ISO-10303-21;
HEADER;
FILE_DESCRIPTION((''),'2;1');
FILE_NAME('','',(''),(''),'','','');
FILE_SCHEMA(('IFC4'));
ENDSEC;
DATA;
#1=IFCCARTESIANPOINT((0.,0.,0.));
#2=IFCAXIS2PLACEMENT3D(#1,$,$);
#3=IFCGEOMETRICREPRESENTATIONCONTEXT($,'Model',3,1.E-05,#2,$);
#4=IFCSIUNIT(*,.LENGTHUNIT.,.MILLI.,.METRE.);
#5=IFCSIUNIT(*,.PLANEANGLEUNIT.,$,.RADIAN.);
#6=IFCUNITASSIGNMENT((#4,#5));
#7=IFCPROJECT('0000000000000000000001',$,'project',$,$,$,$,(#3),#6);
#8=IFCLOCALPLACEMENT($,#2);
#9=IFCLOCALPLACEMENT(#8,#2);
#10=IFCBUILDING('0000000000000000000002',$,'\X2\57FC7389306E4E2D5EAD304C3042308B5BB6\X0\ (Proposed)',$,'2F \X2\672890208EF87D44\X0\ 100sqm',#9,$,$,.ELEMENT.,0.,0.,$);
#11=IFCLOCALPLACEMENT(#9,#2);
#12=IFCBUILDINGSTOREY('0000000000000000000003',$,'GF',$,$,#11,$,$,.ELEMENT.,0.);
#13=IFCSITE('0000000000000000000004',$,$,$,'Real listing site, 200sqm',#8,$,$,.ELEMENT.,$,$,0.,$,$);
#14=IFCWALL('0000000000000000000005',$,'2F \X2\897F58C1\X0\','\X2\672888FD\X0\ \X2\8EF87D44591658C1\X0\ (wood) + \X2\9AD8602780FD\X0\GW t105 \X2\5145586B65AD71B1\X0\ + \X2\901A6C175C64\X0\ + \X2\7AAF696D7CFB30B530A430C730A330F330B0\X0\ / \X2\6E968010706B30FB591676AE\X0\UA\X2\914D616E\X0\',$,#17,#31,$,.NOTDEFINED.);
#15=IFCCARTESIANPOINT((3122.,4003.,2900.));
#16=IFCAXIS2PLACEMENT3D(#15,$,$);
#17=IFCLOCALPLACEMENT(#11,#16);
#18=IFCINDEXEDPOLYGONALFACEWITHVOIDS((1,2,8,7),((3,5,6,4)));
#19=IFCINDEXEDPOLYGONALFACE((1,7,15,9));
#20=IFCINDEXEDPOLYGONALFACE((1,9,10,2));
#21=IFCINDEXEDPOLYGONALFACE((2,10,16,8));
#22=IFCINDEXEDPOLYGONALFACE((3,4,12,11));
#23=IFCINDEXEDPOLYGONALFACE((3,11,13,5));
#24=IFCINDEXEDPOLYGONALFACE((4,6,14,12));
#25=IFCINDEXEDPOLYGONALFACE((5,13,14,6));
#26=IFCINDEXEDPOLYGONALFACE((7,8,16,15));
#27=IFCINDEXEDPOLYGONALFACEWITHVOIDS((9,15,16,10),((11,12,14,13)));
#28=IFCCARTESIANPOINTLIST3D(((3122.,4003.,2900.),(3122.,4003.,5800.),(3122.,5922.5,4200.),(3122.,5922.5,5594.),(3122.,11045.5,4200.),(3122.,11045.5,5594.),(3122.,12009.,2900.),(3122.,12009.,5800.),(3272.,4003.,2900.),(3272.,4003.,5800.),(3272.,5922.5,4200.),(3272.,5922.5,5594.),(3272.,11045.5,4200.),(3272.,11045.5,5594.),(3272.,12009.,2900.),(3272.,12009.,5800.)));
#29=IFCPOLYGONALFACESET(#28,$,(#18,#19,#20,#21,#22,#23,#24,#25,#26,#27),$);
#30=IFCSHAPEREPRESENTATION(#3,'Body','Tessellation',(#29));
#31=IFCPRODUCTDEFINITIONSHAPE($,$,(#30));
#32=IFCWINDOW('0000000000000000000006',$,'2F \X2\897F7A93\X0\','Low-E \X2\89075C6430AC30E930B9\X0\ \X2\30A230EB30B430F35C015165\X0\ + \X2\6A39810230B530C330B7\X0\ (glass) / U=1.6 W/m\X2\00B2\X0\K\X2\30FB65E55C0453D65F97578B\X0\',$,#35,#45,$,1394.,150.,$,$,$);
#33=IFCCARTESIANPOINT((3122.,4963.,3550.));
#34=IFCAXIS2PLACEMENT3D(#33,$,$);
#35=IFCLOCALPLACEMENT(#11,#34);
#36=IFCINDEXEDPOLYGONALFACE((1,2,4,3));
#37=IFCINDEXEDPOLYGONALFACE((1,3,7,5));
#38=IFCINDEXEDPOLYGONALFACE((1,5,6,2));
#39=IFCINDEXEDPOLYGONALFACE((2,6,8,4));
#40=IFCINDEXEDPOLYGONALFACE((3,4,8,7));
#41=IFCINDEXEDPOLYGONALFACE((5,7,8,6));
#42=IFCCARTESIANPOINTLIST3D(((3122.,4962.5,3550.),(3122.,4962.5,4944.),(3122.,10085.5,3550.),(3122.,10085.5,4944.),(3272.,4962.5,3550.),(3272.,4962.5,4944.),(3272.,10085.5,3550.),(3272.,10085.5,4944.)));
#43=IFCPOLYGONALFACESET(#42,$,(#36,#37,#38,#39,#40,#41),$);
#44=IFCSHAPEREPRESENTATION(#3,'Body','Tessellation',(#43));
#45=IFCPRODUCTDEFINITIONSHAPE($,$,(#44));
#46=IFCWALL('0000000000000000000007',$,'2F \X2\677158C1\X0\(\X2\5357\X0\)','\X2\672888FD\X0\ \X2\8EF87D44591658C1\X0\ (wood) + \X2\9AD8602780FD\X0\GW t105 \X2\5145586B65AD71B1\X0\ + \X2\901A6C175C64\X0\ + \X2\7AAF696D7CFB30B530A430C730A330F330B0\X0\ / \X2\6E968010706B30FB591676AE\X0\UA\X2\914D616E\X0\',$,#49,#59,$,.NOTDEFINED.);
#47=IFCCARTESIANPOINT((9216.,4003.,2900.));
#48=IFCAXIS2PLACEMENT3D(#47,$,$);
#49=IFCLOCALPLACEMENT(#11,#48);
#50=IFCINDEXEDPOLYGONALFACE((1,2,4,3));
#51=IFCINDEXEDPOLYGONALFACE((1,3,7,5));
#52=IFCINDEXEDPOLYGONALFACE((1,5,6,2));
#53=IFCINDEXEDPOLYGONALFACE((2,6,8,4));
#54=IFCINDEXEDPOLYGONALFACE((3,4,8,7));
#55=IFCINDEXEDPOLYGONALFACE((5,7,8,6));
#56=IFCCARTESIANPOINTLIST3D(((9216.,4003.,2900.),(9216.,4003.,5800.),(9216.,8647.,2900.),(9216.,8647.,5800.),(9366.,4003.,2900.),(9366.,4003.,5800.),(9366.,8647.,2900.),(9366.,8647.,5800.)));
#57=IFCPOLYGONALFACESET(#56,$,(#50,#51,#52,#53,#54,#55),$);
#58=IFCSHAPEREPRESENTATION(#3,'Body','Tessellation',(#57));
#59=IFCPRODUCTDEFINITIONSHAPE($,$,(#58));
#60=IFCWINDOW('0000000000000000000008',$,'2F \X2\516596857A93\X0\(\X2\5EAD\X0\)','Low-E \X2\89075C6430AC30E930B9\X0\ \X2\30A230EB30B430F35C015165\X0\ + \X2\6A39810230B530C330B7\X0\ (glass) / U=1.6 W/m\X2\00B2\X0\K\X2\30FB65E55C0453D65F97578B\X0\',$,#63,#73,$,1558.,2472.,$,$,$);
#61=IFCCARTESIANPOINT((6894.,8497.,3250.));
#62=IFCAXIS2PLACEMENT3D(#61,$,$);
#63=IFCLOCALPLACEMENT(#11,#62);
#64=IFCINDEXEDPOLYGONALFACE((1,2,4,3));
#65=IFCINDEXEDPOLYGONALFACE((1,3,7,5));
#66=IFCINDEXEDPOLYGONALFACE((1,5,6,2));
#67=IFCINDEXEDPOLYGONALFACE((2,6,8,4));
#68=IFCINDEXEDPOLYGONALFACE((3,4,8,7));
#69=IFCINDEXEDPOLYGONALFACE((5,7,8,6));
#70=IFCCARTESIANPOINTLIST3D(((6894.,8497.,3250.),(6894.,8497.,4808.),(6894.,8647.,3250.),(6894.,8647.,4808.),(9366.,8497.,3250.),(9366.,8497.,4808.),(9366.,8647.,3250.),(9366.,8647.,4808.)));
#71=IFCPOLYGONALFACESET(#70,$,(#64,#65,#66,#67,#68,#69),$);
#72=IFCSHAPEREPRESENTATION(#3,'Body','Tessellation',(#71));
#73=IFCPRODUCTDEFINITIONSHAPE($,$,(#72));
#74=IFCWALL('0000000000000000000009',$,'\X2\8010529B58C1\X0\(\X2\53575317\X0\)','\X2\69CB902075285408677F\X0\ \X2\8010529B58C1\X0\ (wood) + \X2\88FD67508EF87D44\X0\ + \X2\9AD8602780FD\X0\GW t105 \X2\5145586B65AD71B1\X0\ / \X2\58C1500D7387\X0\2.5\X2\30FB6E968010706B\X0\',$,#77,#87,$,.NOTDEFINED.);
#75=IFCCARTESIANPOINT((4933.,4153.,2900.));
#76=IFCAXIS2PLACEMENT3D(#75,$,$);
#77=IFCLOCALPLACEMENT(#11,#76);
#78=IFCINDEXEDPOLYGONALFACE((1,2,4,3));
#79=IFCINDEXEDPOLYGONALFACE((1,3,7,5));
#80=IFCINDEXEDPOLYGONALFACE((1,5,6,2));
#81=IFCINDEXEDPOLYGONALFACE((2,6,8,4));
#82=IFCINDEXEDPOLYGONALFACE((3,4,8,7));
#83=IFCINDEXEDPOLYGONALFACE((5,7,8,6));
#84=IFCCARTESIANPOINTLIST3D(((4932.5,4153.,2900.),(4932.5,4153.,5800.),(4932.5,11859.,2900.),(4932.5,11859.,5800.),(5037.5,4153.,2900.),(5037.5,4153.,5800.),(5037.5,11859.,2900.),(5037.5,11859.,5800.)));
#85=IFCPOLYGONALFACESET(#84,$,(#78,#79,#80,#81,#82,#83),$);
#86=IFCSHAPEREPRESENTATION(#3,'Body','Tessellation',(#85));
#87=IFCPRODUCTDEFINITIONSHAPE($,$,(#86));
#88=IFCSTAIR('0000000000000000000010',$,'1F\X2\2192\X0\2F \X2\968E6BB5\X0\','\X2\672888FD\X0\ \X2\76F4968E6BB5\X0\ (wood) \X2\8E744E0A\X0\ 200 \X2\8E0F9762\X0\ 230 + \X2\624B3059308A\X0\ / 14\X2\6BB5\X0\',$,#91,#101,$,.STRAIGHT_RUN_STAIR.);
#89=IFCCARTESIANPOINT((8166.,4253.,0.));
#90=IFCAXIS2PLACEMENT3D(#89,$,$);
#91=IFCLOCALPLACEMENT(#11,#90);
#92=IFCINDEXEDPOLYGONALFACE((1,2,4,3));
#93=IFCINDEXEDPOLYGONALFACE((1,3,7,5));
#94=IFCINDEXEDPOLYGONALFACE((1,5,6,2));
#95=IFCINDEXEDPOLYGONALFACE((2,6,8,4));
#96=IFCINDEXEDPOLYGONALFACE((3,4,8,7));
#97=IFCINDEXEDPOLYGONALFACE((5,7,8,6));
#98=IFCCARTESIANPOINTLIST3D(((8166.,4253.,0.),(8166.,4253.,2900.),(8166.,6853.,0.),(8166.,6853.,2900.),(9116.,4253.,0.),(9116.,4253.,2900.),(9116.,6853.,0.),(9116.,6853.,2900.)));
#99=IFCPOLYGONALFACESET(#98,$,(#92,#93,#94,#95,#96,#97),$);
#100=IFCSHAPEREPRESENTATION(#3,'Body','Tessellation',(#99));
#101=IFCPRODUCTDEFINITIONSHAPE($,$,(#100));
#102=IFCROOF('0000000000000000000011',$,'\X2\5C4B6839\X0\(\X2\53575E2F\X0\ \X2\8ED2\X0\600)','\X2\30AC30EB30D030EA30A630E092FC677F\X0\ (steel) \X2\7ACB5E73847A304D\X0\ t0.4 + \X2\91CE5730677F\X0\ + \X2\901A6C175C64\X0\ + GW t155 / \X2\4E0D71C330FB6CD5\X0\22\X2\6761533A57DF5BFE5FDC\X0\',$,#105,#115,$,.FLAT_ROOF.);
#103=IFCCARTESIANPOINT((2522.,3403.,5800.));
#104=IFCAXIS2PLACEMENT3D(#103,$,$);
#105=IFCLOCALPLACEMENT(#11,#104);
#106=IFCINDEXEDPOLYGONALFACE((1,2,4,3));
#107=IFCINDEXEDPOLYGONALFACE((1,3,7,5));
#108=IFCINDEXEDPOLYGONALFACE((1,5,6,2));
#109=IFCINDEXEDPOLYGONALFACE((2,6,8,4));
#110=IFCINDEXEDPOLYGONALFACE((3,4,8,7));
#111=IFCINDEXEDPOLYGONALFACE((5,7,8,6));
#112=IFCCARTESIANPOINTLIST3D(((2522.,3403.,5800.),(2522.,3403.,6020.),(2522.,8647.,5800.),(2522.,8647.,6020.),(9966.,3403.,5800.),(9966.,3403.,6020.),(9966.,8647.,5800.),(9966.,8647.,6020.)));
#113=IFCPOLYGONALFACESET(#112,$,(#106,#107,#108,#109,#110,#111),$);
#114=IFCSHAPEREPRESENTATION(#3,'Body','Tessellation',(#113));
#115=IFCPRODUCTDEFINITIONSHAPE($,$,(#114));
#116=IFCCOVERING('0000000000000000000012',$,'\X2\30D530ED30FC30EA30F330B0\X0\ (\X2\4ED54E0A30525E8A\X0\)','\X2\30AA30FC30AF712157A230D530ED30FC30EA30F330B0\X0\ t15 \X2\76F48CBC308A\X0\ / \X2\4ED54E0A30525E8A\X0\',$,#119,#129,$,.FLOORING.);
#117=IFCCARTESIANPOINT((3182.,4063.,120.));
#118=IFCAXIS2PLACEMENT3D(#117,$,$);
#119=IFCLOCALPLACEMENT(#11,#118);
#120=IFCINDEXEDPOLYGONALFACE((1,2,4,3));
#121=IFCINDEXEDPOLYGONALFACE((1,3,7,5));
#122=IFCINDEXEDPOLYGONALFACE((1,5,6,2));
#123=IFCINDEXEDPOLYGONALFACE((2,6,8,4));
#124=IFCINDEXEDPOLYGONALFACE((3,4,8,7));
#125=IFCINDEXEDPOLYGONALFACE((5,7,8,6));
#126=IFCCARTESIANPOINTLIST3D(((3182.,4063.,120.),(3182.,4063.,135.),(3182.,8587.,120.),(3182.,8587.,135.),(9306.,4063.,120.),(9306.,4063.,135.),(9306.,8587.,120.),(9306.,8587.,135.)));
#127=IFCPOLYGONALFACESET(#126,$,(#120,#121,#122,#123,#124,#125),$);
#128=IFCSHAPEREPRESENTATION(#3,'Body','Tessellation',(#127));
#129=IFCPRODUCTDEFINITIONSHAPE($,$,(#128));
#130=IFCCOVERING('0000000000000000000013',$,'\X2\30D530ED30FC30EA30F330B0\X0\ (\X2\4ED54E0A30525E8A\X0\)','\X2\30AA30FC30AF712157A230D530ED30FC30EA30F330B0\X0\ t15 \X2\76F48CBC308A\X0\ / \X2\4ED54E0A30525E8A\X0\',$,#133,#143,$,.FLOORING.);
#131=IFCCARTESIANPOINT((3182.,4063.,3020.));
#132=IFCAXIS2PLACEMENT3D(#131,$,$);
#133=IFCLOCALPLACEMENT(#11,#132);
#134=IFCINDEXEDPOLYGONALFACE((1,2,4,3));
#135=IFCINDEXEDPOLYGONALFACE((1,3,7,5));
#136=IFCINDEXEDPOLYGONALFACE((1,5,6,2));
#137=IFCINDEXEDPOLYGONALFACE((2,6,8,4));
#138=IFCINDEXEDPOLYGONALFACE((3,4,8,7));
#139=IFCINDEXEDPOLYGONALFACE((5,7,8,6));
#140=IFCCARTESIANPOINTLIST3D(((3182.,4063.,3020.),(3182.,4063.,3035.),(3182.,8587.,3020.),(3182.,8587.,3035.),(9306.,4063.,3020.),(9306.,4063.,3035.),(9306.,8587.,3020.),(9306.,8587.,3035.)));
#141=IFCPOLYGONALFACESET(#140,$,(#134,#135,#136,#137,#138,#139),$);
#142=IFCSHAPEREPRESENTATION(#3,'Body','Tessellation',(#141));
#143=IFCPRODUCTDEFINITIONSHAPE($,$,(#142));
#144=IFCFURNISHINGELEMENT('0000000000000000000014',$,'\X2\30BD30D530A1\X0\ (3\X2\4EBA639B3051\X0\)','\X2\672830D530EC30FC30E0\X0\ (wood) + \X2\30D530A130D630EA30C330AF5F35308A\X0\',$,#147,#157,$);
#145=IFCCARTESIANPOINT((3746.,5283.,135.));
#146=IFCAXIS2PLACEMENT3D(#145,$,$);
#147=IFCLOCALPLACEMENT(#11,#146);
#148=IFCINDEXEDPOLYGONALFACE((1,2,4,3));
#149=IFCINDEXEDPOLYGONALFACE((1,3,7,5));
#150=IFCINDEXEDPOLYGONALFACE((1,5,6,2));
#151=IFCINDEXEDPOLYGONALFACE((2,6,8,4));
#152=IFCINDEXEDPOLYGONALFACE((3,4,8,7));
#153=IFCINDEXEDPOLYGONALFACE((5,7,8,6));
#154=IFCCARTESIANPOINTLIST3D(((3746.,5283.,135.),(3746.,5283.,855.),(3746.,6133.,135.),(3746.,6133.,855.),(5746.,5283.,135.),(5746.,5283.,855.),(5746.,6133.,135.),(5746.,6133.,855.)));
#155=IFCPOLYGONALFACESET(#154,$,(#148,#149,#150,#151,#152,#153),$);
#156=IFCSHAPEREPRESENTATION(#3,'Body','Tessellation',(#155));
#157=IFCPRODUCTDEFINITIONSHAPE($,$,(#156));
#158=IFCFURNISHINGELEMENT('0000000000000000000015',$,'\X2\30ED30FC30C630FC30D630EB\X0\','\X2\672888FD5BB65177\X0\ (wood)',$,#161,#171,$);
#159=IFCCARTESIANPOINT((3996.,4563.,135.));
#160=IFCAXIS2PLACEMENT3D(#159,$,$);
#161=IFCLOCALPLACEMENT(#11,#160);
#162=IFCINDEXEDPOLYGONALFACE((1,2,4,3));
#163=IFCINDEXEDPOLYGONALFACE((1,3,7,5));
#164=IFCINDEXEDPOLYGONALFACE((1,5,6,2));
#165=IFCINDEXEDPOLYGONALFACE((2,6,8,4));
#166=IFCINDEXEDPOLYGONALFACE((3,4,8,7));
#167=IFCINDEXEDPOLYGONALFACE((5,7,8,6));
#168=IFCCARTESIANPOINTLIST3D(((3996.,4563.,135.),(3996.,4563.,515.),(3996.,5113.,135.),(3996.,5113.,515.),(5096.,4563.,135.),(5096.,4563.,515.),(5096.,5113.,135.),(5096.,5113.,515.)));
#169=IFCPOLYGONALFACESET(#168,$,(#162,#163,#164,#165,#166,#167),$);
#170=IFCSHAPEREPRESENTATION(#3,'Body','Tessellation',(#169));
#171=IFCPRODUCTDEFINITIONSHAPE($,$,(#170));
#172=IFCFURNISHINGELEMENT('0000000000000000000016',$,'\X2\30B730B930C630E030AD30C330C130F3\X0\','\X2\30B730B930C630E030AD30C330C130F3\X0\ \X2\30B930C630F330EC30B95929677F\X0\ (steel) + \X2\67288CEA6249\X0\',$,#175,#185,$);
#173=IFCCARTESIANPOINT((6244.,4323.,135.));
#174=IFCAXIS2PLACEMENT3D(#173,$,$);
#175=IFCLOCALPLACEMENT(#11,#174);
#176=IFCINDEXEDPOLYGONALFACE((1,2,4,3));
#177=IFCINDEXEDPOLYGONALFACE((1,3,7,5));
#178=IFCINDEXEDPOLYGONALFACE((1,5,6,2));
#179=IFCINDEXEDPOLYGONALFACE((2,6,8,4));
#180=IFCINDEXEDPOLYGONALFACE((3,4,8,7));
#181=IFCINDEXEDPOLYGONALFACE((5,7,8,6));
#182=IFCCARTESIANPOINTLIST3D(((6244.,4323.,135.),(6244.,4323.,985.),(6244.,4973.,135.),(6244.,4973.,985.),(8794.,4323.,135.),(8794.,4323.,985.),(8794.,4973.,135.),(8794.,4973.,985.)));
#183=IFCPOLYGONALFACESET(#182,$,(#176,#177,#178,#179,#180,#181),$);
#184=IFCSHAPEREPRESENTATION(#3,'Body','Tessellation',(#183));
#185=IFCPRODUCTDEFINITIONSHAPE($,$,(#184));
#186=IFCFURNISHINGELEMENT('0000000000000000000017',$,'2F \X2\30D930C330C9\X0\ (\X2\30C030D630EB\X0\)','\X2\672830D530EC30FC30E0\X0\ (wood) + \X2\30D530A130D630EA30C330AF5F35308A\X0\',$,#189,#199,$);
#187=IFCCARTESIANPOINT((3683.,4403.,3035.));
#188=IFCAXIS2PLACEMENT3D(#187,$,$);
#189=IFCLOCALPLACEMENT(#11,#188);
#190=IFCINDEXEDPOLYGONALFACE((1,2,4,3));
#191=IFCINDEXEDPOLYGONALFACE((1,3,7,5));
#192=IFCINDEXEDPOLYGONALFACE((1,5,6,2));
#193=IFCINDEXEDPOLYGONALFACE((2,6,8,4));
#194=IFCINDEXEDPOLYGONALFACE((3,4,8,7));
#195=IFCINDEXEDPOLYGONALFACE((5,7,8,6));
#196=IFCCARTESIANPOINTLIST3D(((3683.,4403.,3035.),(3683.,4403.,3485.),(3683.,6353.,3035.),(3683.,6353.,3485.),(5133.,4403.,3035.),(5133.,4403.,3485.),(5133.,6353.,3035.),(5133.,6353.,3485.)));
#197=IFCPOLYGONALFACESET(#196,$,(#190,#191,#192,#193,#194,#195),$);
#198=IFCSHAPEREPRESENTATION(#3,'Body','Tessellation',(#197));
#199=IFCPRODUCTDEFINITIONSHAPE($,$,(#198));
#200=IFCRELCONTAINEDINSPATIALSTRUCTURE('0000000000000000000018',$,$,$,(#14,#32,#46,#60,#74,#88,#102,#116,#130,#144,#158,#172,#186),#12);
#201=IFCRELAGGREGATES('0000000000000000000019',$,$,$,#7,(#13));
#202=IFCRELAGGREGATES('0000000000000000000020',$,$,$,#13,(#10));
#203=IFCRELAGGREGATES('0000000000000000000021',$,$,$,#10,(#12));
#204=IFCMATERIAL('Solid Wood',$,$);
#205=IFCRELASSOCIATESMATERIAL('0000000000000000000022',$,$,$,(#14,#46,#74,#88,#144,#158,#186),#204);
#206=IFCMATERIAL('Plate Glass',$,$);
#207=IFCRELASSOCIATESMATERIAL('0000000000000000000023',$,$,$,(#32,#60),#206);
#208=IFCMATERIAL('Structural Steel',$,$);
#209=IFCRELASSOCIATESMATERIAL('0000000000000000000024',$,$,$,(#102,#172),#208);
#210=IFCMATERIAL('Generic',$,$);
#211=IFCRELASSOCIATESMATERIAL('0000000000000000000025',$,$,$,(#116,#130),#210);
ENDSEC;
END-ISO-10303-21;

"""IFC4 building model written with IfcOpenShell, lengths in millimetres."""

from ifc_helpers import new_model, si_unit, frame, frame_2d, origin, place, context, project, spatial, rectangle, extrude, material, element, fill, save


model = new_model("IFC4")

# Units and contexts
model_context = context("Model", 3, precision=1e-05, world=origin())
ifc_project = project(units=[si_unit("LENGTHUNIT", "METRE", prefix="MILLI"), si_unit("PLANEANGLEUNIT", "RADIAN")], contexts=[model_context])

# Site, building, storey
site_placement = place(None, origin())
site = spatial("IfcSite", under=ifc_project, at=site_placement, ObjectType="Real listing site, 200sqm", CompositionType="ELEMENT", RefElevation=0.0)
building_placement = place(site_placement, origin())
building = spatial("IfcBuilding", under=site, at=building_placement, Name="埼玉の中庭がある家 (Proposed)", ObjectType="2F 木造軸組 100sqm", CompositionType="ELEMENT", ElevationOfRefHeight=0.0, ElevationOfTerrain=0.0)
storey_placement = place(building_placement, origin())
storey = spatial("IfcBuildingStorey", under=building, at=storey_placement, Name="GF", CompositionType="ELEMENT", Elevation=0.0)

# Shared definitions
ifc_material_1 = material(Name="Solid Wood")

# Shared definitions
ifc_material_2 = material(Name="Plate Glass")

# Walls, openings, windows
wall_1_placement = place(storey_placement, frame((3122.0, 4003.0, 2900.0)))
wall_1 = element("IfcWall", 1, at=wall_1_placement, inside=storey, material=ifc_material_1, Name="2F 西壁", Description="木製 軸組外壁 (wood) + 高性能GW t105 充填断熱 + 通気層 + 窯業系サイディング / 準耐火・外皮UA配慮", PredefinedType="NOTDEFINED", context=model_context, shape_type="SweptSolid", body=[
    extrude(rectangle(XDim=150.0, YDim=8006.0, at=frame_2d((75.0, 4003.0))), frame((3122.0, 4003.0, 2900.0)), (0.0, 0.0, 1.0), 2900.0),
])
opening_1_placement = place(storey_placement, frame((3122.0, 4963.0, 3550.0)))
opening_1 = element("IfcOpeningElement", 2, at=opening_1_placement, cuts=wall_1, PredefinedType="NOTDEFINED", context=model_context, shape_type="SweptSolid", body=[
    extrude(rectangle(XDim=150.0, YDim=5123.0, at=frame_2d((75.0, 2561.0))), frame((3122.0, 4963.0, 3550.0)), (0.0, 0.0, 1.0), 1394.0),
])
window_1_placement = place(storey_placement, frame((3122.0, 4963.0, 3550.0)))
window_1 = element("IfcWindow", 3, at=window_1_placement, inside=storey, material=ifc_material_2, Name="2F 西窓", Description="Low-E 複層ガラス アルゴン封入 + 樹脂サッシ (glass) / U=1.6 W/m²K・日射取得型", OverallHeight=1394.0, OverallWidth=150.0, context=model_context, shape_type="SweptSolid", body=[
    extrude(rectangle(XDim=150.0, YDim=5123.0, at=frame_2d((75.0, 2561.0))), frame((3122.0, 4963.0, 3550.0)), (0.0, 0.0, 1.0), 1394.0),
])
fill(opening_1, window_1)
wall_2_placement = place(storey_placement, frame((9216.0, 4003.0, 2900.0)))
wall_2 = element("IfcWall", 4, at=wall_2_placement, inside=storey, material=ifc_material_1, Name="2F 東壁(南)", Description="木製 軸組外壁 (wood) + 高性能GW t105 充填断熱 + 通気層 + 窯業系サイディング / 準耐火・外皮UA配慮", PredefinedType="NOTDEFINED", context=model_context, shape_type="SweptSolid", body=[
    extrude(rectangle(XDim=150.0, YDim=4644.0, at=frame_2d((75.0, 2322.0))), frame((9216.0, 4003.0, 2900.0)), (0.0, 0.0, 1.0), 2900.0),
])
opening_2_placement = place(storey_placement, frame((6894.0, 8497.0, 3250.0)))
opening_2 = element("IfcOpeningElement", 5, at=opening_2_placement, cuts=wall_2, PredefinedType="NOTDEFINED", context=model_context, shape_type="SweptSolid", body=[
    extrude(rectangle(XDim=2472.0, YDim=150.0, at=frame_2d((1236.0, 75.0))), frame((6894.0, 8497.0, 3250.0)), (0.0, 0.0, 1.0), 1558.0),
])
window_2_placement = place(storey_placement, frame((6894.0, 8497.0, 3250.0)))
window_2 = element("IfcWindow", 6, at=window_2_placement, inside=storey, material=ifc_material_2, Name="2F 入隅窓(庭)", Description="Low-E 複層ガラス アルゴン封入 + 樹脂サッシ (glass) / U=1.6 W/m²K・日射取得型", OverallHeight=1558.0, OverallWidth=2472.0, context=model_context, shape_type="SweptSolid", body=[
    extrude(rectangle(XDim=2472.0, YDim=150.0, at=frame_2d((1236.0, 75.0))), frame((6894.0, 8497.0, 3250.0)), (0.0, 0.0, 1.0), 1558.0),
])
fill(opening_2, window_2)

# Wall
wall_3_placement = place(storey_placement, frame((4933.0, 4153.0, 2900.0)))
element("IfcWall", 7, at=wall_3_placement, inside=storey, material=ifc_material_1, Name="耐力壁(南北)", Description="構造用合板 耐力壁 (wood) + 製材軸組 + 高性能GW t105 充填断熱 / 壁倍率2.5・準耐火", PredefinedType="NOTDEFINED", context=model_context, shape_type="SweptSolid", body=[
    extrude(rectangle(XDim=105.0, YDim=7706.0, at=frame_2d((52.0, 3853.0))), frame((4933.0, 4153.0, 2900.0)), (0.0, 0.0, 1.0), 2900.0),
])

# Stair
stair_placement = place(storey_placement, frame((8166.0, 4253.0, 0.0)))
element("IfcStair", 8, at=stair_placement, inside=storey, material=ifc_material_1, Name="1F→2F 階段", Description="木製 直階段 (wood) 蹴上 200 踏面 230 + 手すり / 14段", PredefinedType="STRAIGHT_RUN_STAIR", context=model_context, shape_type="SweptSolid", body=[
    extrude(rectangle(XDim=950.0, YDim=2600.0, at=frame_2d((475.0, 1300.0))), frame((8166.0, 4253.0, 0.0)), (0.0, 0.0, 1.0), 2900.0),
])

# Roof
ifc_material_3 = material(Name="Structural Steel")
for number, where, name in (
    (9, (2522.0, 3403.0, 5800.0), "屋根(南帯 軒600)"),
):
    element("IfcRoof", number, at=place(storey_placement, frame(where)), inside=storey, material=ifc_material_3, Name=name, Description="ガルバリウム鋼板 (steel) 立平葺き t0.4 + 野地板 + 通気層 + GW t155 / 不燃・法22条区域対応", PredefinedType="FLAT_ROOF", context=model_context, shape_type="SweptSolid", body=[
        extrude(rectangle(XDim=7444.0, YDim=5244.0, at=frame_2d((3722.0, 2622.0))), frame((2522.0, 3403.0, 5800.0)), (0.0, 0.0, 1.0), 220.0),
    ])

# Coverings
ifc_material_4 = material(Name="Generic")
covering_1_placement = place(storey_placement, frame((3182.0, 4063.0, 120.0)))
element("IfcCovering", 10, at=covering_1_placement, inside=storey, material=ifc_material_4, Name="フローリング (仕上げ床)", Description="オーク無垢フローリング t15 直貼り / 仕上げ床", PredefinedType="FLOORING", context=model_context, shape_type="SweptSolid", body=[
    extrude(rectangle(XDim=6124.0, YDim=4524.0, at=frame_2d((3062.0, 2262.0))), frame((3182.0, 4063.0, 120.0)), (0.0, 0.0, 1.0), 15.0),
])
covering_2_placement = place(storey_placement, frame((3182.0, 4063.0, 3020.0)))
element("IfcCovering", 11, at=covering_2_placement, inside=storey, material=ifc_material_4, Name="フローリング (仕上げ床)", Description="オーク無垢フローリング t15 直貼り / 仕上げ床", PredefinedType="FLOORING", context=model_context, shape_type="SweptSolid", body=[
    extrude(rectangle(XDim=6124.0, YDim=4524.0, at=frame_2d((3062.0, 2262.0))), frame((3182.0, 4063.0, 3020.0)), (0.0, 0.0, 1.0), 15.0),
])

# Furnishing elements
furnishing_1_placement = place(storey_placement, frame((3746.0, 5283.0, 135.0)))
element("IfcFurnishingElement", 12, at=furnishing_1_placement, inside=storey, material=ifc_material_1, Name="ソファ (3人掛け)", Description="木フレーム (wood) + ファブリック張り", context=model_context, shape_type="SweptSolid", body=[
    extrude(rectangle(XDim=2000.0, YDim=850.0, at=frame_2d((1000.0, 425.0))), frame((3746.0, 5283.0, 135.0)), (0.0, 0.0, 1.0), 720.0),
])
furnishing_2_placement = place(storey_placement, frame((3996.0, 4563.0, 135.0)))
element("IfcFurnishingElement", 13, at=furnishing_2_placement, inside=storey, material=ifc_material_1, Name="ローテーブル", Description="木製家具 (wood)", context=model_context, shape_type="SweptSolid", body=[
    extrude(rectangle(XDim=1100.0, YDim=550.0, at=frame_2d((550.0, 275.0))), frame((3996.0, 4563.0, 135.0)), (0.0, 0.0, 1.0), 380.0),
])
furnishing_3_placement = place(storey_placement, frame((6244.0, 4323.0, 135.0)))
element("IfcFurnishingElement", 14, at=furnishing_3_placement, inside=storey, material=ifc_material_3, Name="システムキッチン", Description="システムキッチン ステンレス天板 (steel) + 木質扉", context=model_context, shape_type="SweptSolid", body=[
    extrude(rectangle(XDim=2550.0, YDim=650.0, at=frame_2d((1275.0, 325.0))), frame((6244.0, 4323.0, 135.0)), (0.0, 0.0, 1.0), 850.0),
])
furnishing_4_placement = place(storey_placement, frame((3683.0, 4403.0, 3035.0)))
element("IfcFurnishingElement", 15, at=furnishing_4_placement, inside=storey, material=ifc_material_1, Name="2F ベッド (ダブル)", Description="木フレーム (wood) + ファブリック張り", context=model_context, shape_type="SweptSolid", body=[
    extrude(rectangle(XDim=1450.0, YDim=1950.0, at=frame_2d((725.0, 975.0))), frame((3683.0, 4403.0, 3035.0)), (0.0, 0.0, 1.0), 450.0),
])

save(model, "model.ifc")
